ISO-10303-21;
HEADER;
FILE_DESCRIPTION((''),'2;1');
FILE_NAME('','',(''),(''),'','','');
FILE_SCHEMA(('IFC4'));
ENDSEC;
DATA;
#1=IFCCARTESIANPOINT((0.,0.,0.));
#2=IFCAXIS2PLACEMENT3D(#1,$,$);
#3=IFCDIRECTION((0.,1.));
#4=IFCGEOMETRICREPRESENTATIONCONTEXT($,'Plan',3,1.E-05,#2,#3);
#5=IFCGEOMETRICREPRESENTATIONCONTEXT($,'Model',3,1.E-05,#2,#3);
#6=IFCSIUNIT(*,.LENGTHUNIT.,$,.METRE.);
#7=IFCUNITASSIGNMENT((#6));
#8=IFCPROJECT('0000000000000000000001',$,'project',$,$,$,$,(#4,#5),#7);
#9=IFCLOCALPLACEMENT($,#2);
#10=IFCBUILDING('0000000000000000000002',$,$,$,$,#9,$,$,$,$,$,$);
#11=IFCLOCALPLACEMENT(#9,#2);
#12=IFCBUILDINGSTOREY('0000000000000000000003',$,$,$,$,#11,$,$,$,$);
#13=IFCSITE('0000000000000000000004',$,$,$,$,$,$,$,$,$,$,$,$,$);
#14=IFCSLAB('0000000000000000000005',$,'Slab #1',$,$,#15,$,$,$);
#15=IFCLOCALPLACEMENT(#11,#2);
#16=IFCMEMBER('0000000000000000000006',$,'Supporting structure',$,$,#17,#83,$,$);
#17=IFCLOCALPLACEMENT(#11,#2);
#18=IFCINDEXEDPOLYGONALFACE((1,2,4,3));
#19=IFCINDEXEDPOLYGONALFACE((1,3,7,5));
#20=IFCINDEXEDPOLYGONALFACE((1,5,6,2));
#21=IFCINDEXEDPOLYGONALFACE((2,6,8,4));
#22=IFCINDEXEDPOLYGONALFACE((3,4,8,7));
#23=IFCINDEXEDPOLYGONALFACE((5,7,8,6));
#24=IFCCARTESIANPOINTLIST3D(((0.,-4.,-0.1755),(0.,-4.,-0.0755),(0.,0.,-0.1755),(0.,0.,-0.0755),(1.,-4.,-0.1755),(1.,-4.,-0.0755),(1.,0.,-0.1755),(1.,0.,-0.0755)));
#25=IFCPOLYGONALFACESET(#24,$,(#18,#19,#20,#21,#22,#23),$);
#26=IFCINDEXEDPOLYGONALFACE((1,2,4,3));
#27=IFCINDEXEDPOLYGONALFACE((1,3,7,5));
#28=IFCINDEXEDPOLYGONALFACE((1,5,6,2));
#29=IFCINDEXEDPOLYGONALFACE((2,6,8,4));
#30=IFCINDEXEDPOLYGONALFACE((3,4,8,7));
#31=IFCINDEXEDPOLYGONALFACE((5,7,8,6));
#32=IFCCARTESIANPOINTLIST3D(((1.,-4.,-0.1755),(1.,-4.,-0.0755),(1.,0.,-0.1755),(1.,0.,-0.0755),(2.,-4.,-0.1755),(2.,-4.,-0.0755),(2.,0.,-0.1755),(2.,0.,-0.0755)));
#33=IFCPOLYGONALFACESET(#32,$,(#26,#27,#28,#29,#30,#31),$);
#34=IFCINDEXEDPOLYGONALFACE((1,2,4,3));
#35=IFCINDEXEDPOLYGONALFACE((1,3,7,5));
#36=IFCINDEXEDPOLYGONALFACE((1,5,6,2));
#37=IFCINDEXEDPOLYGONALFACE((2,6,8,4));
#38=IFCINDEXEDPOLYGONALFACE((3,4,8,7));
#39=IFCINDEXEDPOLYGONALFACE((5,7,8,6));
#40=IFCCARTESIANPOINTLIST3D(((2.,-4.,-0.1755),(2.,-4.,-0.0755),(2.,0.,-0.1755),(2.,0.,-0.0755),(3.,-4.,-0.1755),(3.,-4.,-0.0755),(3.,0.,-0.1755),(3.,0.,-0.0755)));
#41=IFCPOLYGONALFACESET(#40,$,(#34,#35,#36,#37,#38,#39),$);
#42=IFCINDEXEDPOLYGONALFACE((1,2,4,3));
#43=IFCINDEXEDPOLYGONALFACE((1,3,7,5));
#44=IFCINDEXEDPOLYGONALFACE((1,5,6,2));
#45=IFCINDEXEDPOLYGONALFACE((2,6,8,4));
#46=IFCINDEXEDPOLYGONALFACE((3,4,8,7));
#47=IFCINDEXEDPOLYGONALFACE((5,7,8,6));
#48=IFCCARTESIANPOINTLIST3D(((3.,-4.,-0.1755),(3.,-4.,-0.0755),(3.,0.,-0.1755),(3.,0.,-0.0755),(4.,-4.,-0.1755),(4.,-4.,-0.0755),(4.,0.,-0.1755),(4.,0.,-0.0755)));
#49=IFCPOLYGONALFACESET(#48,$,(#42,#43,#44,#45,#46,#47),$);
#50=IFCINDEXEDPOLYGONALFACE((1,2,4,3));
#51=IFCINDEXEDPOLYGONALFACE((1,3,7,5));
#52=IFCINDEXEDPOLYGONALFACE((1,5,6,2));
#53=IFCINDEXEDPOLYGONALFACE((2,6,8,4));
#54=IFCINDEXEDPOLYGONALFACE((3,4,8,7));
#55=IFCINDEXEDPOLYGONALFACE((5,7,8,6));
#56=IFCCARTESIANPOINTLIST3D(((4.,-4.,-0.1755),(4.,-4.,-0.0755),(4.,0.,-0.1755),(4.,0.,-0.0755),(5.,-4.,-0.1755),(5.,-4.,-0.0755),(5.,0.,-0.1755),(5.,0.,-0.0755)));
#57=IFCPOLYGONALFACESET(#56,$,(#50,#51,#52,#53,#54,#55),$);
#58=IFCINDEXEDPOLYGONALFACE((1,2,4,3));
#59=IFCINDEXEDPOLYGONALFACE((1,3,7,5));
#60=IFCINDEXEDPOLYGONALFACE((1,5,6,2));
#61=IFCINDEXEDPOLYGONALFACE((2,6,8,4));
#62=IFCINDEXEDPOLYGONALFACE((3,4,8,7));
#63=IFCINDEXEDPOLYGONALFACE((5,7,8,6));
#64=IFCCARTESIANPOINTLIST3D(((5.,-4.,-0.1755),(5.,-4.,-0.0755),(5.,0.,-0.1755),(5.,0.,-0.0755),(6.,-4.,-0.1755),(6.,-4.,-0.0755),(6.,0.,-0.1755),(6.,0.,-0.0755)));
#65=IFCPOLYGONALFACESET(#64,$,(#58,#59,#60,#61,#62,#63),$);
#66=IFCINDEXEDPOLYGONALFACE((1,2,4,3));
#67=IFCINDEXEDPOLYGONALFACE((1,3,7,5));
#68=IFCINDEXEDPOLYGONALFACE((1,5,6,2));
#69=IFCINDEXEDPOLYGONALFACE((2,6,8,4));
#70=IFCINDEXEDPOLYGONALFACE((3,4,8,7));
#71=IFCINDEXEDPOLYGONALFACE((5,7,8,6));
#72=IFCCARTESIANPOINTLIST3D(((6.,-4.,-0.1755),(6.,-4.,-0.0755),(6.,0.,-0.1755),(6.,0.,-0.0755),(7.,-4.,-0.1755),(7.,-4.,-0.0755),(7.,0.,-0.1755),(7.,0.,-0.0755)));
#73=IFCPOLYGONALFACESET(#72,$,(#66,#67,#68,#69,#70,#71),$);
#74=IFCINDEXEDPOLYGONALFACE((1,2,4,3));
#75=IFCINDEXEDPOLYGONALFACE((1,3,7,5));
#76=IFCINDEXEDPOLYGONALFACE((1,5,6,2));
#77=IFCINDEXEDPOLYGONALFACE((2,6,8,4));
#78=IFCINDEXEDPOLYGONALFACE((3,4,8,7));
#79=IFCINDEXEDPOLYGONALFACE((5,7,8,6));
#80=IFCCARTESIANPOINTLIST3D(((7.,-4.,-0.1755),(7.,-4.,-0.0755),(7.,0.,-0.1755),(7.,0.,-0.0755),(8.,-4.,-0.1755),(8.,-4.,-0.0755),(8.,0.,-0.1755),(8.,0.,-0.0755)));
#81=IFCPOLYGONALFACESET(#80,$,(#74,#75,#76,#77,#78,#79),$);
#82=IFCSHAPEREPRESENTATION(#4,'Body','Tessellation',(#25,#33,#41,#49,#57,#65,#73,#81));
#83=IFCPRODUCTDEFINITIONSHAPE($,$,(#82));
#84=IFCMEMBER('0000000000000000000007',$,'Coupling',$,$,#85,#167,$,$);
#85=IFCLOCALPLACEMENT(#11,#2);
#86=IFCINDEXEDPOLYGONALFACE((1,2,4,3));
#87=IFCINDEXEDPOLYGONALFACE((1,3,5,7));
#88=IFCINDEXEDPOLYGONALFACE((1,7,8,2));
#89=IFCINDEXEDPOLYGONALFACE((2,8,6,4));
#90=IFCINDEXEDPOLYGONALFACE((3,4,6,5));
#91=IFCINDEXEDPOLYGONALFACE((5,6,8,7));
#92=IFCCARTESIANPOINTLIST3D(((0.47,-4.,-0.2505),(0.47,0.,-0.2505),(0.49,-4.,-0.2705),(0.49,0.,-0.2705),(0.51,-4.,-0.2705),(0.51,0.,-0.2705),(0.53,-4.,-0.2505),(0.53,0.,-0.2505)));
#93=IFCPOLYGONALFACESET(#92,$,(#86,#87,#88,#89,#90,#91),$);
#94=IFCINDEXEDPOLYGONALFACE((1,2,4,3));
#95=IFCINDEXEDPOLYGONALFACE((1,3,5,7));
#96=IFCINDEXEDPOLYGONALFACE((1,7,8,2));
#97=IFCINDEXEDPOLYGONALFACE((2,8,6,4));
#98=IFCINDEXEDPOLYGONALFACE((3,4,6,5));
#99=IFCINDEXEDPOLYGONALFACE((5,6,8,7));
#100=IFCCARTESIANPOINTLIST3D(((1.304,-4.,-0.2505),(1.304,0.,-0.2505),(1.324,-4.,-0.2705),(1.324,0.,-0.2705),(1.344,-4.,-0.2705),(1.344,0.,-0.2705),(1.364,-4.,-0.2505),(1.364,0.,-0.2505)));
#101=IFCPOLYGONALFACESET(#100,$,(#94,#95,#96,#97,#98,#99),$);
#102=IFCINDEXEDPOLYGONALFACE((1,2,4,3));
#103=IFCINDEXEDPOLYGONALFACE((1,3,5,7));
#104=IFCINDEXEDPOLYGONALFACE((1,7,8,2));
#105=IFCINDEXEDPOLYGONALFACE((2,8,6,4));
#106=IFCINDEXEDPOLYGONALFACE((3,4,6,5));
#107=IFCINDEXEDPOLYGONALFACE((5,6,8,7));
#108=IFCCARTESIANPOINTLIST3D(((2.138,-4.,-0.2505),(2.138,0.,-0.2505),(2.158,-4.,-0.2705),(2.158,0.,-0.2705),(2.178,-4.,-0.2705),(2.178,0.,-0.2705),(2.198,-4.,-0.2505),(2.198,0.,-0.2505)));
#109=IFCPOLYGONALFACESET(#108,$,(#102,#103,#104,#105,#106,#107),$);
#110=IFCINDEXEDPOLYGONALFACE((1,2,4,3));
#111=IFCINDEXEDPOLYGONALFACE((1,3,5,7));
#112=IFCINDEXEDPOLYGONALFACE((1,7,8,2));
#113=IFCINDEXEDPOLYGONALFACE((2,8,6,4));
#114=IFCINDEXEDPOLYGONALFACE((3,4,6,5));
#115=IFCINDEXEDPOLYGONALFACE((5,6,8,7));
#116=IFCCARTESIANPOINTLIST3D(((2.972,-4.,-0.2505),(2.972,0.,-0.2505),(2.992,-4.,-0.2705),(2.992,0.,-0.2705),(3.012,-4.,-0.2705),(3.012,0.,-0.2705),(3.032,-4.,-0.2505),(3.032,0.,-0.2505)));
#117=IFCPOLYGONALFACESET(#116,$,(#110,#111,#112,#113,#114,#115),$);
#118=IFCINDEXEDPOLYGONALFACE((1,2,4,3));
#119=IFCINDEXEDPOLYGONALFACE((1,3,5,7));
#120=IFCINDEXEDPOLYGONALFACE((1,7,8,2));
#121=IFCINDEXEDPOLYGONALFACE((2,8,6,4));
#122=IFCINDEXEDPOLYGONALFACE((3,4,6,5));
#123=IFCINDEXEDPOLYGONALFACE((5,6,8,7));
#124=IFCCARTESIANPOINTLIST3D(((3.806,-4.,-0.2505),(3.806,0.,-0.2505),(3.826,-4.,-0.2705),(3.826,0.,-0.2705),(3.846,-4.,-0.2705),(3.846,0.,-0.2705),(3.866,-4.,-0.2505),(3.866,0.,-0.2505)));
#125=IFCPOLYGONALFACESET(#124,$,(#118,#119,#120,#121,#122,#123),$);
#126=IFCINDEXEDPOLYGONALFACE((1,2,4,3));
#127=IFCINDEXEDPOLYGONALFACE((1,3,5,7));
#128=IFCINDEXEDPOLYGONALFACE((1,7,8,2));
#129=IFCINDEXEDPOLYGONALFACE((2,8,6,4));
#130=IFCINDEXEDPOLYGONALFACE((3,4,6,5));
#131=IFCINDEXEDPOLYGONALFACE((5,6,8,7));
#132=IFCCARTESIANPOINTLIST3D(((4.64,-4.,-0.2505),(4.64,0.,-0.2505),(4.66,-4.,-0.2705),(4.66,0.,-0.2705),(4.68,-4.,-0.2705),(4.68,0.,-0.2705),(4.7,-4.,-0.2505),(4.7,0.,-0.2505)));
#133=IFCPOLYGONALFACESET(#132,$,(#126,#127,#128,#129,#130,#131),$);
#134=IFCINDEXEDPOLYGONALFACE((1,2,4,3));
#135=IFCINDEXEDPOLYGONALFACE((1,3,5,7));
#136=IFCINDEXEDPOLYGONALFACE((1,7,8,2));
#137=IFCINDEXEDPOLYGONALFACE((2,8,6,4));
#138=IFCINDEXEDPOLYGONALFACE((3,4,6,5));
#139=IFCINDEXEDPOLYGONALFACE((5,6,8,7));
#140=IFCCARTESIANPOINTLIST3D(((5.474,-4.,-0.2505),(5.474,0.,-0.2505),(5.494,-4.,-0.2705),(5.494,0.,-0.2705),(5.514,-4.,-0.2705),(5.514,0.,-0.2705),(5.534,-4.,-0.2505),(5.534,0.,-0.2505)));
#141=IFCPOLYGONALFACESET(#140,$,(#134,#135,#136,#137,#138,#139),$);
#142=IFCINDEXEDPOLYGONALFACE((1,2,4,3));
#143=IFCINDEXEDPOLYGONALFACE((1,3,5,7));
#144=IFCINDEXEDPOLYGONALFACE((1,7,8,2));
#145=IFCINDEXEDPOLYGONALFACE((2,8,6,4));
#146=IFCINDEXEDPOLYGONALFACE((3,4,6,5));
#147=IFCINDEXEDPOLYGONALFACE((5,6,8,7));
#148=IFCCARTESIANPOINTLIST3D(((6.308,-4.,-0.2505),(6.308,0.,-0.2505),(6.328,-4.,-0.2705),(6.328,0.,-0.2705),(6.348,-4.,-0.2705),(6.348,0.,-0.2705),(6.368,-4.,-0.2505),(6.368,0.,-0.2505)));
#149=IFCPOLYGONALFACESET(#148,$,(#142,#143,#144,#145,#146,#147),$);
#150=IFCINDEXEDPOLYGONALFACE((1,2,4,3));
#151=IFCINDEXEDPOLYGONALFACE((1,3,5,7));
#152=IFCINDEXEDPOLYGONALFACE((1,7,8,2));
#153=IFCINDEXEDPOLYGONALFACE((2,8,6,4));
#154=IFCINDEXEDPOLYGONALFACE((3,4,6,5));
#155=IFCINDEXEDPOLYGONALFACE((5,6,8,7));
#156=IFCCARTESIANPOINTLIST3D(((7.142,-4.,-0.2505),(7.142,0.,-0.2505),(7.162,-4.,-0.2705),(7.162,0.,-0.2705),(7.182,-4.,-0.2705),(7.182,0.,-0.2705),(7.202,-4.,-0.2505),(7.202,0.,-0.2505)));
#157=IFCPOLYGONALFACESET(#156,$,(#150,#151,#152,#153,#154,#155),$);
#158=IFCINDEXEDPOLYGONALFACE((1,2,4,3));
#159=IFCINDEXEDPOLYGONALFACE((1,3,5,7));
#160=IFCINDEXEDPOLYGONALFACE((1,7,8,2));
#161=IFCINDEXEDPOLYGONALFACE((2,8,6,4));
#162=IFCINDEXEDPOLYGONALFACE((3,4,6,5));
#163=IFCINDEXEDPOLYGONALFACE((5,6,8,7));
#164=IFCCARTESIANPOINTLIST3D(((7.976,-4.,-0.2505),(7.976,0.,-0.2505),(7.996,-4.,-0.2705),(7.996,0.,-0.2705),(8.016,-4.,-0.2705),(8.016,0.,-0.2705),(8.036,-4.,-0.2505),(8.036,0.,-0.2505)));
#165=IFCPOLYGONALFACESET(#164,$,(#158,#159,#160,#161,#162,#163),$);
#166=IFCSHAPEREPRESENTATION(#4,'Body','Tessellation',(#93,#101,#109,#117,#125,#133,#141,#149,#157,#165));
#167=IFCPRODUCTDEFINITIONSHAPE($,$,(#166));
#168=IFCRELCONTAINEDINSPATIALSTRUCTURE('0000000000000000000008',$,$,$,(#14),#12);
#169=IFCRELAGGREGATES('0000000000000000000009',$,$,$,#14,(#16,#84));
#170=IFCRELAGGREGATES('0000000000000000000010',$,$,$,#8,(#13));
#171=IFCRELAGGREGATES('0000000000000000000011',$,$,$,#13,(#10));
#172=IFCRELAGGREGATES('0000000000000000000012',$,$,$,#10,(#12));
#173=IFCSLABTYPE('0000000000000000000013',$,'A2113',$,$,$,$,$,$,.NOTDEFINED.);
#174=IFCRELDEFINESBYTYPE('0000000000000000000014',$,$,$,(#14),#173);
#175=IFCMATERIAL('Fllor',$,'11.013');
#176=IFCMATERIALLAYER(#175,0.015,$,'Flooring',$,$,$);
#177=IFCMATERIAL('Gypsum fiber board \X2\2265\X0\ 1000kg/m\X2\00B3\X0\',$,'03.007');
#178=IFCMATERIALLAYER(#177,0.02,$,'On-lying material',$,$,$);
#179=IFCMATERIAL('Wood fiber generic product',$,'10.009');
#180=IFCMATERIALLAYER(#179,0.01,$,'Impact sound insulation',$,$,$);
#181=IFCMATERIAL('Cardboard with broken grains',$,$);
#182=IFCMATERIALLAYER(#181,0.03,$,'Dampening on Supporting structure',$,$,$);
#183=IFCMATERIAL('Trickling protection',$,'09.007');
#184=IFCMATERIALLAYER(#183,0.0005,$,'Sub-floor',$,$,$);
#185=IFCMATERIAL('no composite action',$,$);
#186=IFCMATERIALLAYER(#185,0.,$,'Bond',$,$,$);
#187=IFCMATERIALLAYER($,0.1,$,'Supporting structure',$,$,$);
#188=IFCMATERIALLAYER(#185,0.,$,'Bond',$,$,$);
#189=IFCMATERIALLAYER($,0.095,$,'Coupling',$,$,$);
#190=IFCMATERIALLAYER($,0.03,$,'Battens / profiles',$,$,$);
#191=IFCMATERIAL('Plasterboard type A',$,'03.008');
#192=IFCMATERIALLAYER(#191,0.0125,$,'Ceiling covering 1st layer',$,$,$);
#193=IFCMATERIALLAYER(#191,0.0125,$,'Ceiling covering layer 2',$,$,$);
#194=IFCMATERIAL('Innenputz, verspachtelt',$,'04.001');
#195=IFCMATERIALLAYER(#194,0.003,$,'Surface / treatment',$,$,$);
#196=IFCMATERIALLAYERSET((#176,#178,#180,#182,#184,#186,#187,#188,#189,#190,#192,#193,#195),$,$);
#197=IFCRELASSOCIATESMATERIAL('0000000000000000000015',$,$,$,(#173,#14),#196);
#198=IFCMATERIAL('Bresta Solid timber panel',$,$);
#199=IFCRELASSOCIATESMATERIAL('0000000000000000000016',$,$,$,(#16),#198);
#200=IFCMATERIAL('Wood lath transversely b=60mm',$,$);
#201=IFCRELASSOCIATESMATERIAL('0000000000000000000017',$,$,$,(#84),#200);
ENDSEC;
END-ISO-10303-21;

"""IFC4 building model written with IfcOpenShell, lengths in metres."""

from ifc_helpers import new_model, si_unit, direction, frame, frame_2d, origin, place, context, project, spatial, polyline, rectangle, outline, extrude, material, layer, layer_set, type_object, element, aggregate, save


model = new_model("IFC4")

# Units and contexts
plan_context = context("Plan", 3, precision=1e-05, world=origin(), true_north=direction((0.0, 1.0)))
model_context = context("Model", 3, precision=1e-05, world=origin(), true_north=direction((0.0, 1.0)))
ifc_project = project(units=[si_unit("LENGTHUNIT", "METRE")], contexts=[plan_context, model_context])

# Site, building, storey
site = spatial("IfcSite", under=ifc_project)
building_placement = place(None, origin())
building = spatial("IfcBuilding", under=site, at=building_placement)
storey_placement = place(building_placement, origin())
storey = spatial("IfcBuildingStorey", under=building, at=storey_placement)

# Slab, members
ifc_material_1 = material(Name="Fllor", Category="11.013")
ifc_layer_1 = layer(ifc_material_1, 0.015, Name="Flooring")
ifc_material_2 = material(Name="Gypsum fiber board ≥ 1000kg/m³", Category="03.007")
ifc_layer_2 = layer(ifc_material_2, 0.02, Name="On-lying material")
ifc_material_3 = material(Name="Wood fiber generic product", Category="10.009")
ifc_layer_3 = layer(ifc_material_3, 0.01, Name="Impact sound insulation")
ifc_material_4 = material(Name="Cardboard with broken grains")
ifc_layer_4 = layer(ifc_material_4, 0.03, Name="Dampening on Supporting structure")
ifc_material_5 = material(Name="Trickling protection", Category="09.007")
ifc_layer_5 = layer(ifc_material_5, 0.0005, Name="Sub-floor")
ifc_material_6 = material(Name="no composite action")
ifc_layer_6 = layer(ifc_material_6, 0.0, Name="Bond")
ifc_layer_7 = layer(None, 0.1, Name="Supporting structure")
ifc_layer_8 = layer(ifc_material_6, 0.0, Name="Bond")
ifc_layer_9 = layer(None, 0.095, Name="Coupling")
ifc_layer_10 = layer(None, 0.03, Name="Battens / profiles")
ifc_material_7 = material(Name="Plasterboard type A", Category="03.008")
ifc_layer_11 = layer(ifc_material_7, 0.0125, Name="Ceiling covering 1st layer")
ifc_layer_12 = layer(ifc_material_7, 0.0125, Name="Ceiling covering layer 2")
ifc_material_8 = material(Name="Innenputz, verspachtelt", Category="04.001")
ifc_layer_13 = layer(ifc_material_8, 0.003, Name="Surface / treatment")
ifc_layer_set = layer_set([ifc_layer_1, ifc_layer_2, ifc_layer_3, ifc_layer_4, ifc_layer_5, ifc_layer_6, ifc_layer_7, ifc_layer_8, ifc_layer_9, ifc_layer_10, ifc_layer_11, ifc_layer_12, ifc_layer_13])
slab_type = type_object("IfcSlabType", Name="A2113", PredefinedType="NOTDEFINED", material=ifc_layer_set)
slab_placement = place(None, frame((0.0, 0.0, 0.0), z_axis=(0.0, 0.0, -1.0), x_axis=(1.0, 0.0, 0.0)))
slab = element("IfcSlab", 1, at=slab_placement, inside=storey, type_object=slab_type, material=ifc_layer_set, Name="Slab #1")
ifc_material_9 = material(Name="Bresta Solid timber panel")
member_1_placement = place(slab_placement, origin())
member_1 = element("IfcMember", 2, at=member_1_placement, material=ifc_material_9, Name="Supporting structure", context=plan_context, shape_type="SweptSolid", body=[
    extrude(rectangle(XDim=1.0, YDim=0.1, at=frame_2d((0.5, 0.05), x_axis=(1.0, 0.0))), frame((0.0, 4.0, 0.0755), z_axis=(0.0, -1.0, 0.0), x_axis=(1.0, 0.0, 0.0)), (0.0, 0.0, 1.0), 4.0),
    extrude(rectangle(XDim=1.0, YDim=0.1, at=frame_2d((0.5, 0.05), x_axis=(1.0, 0.0))), frame((1.0, 4.0, 0.0755), z_axis=(0.0, -1.0, 0.0), x_axis=(1.0, 0.0, 0.0)), (0.0, 0.0, 1.0), 4.0),
    extrude(rectangle(XDim=1.0, YDim=0.1, at=frame_2d((0.5, 0.05), x_axis=(1.0, 0.0))), frame((2.0, 4.0, 0.0755), z_axis=(0.0, -1.0, 0.0), x_axis=(1.0, 0.0, 0.0)), (0.0, 0.0, 1.0), 4.0),
    extrude(rectangle(XDim=1.0, YDim=0.1, at=frame_2d((0.5, 0.05), x_axis=(1.0, 0.0))), frame((3.0, 4.0, 0.0755), z_axis=(0.0, -1.0, 0.0), x_axis=(1.0, 0.0, 0.0)), (0.0, 0.0, 1.0), 4.0),
    extrude(rectangle(XDim=1.0, YDim=0.1, at=frame_2d((0.5, 0.05), x_axis=(1.0, 0.0))), frame((4.0, 4.0, 0.0755), z_axis=(0.0, -1.0, 0.0), x_axis=(1.0, 0.0, 0.0)), (0.0, 0.0, 1.0), 4.0),
    extrude(rectangle(XDim=1.0, YDim=0.1, at=frame_2d((0.5, 0.05), x_axis=(1.0, 0.0))), frame((5.0, 4.0, 0.0755), z_axis=(0.0, -1.0, 0.0), x_axis=(1.0, 0.0, 0.0)), (0.0, 0.0, 1.0), 4.0),
    extrude(rectangle(XDim=1.0, YDim=0.1, at=frame_2d((0.5, 0.05), x_axis=(1.0, 0.0))), frame((6.0, 4.0, 0.0755), z_axis=(0.0, -1.0, 0.0), x_axis=(1.0, 0.0, 0.0)), (0.0, 0.0, 1.0), 4.0),
    extrude(rectangle(XDim=1.0, YDim=0.1, at=frame_2d((0.5, 0.05), x_axis=(1.0, 0.0))), frame((7.0, 4.0, 0.0755), z_axis=(0.0, -1.0, 0.0), x_axis=(1.0, 0.0, 0.0)), (0.0, 0.0, 1.0), 4.0),
])
ifc_material_10 = material(Name="Wood lath transversely b=60mm")
member_2_placement = place(slab_placement, origin())
member_2 = element("IfcMember", 3, at=member_2_placement, material=ifc_material_10, Name="Coupling", context=plan_context, shape_type="SweptSolid", body=[
    extrude(outline(polyline([(0.0, 0.0), (0.06, 0.0), (0.04, 0.02), (0.02, 0.02), (0.0, 0.0)])), frame((0.47, 4.0, 0.2505), z_axis=(0.0, -1.0, 0.0), x_axis=(1.0, 0.0, 0.0)), (0.0, 0.0, 1.0), 4.0),
    extrude(outline(polyline([(0.0, 0.0), (0.06, 0.0), (0.04, 0.02), (0.02, 0.02), (0.0, 0.0)])), frame((1.304, 4.0, 0.2505), z_axis=(0.0, -1.0, 0.0), x_axis=(1.0, 0.0, 0.0)), (0.0, 0.0, 1.0), 4.0),
    extrude(outline(polyline([(0.0, 0.0), (0.06, 0.0), (0.04, 0.02), (0.02, 0.02), (0.0, 0.0)])), frame((2.138, 4.0, 0.2505), z_axis=(0.0, -1.0, 0.0), x_axis=(1.0, 0.0, 0.0)), (0.0, 0.0, 1.0), 4.0),
    extrude(outline(polyline([(0.0, 0.0), (0.06, 0.0), (0.04, 0.02), (0.02, 0.02), (0.0, 0.0)])), frame((2.972, 4.0, 0.2505), z_axis=(0.0, -1.0, 0.0), x_axis=(1.0, 0.0, 0.0)), (0.0, 0.0, 1.0), 4.0),
    extrude(outline(polyline([(0.0, 0.0), (0.06, 0.0), (0.04, 0.02), (0.02, 0.02), (0.0, 0.0)])), frame((3.806, 4.0, 0.2505), z_axis=(0.0, -1.0, 0.0), x_axis=(1.0, 0.0, 0.0)), (0.0, 0.0, 1.0), 4.0),
    extrude(outline(polyline([(0.0, 0.0), (0.06, 0.0), (0.04, 0.02), (0.02, 0.02), (0.0, 0.0)])), frame((4.64, 4.0, 0.2505), z_axis=(0.0, -1.0, 0.0), x_axis=(1.0, 0.0, 0.0)), (0.0, 0.0, 1.0), 4.0),
    extrude(outline(polyline([(0.0, 0.0), (0.06, 0.0), (0.04, 0.02), (0.02, 0.02), (0.0, 0.0)])), frame((5.474, 4.0, 0.2505), z_axis=(0.0, -1.0, 0.0), x_axis=(1.0, 0.0, 0.0)), (0.0, 0.0, 1.0), 4.0),
    extrude(outline(polyline([(0.0, 0.0), (0.06, 0.0), (0.04, 0.02), (0.02, 0.02), (0.0, 0.0)])), frame((6.308, 4.0, 0.2505), z_axis=(0.0, -1.0, 0.0), x_axis=(1.0, 0.0, 0.0)), (0.0, 0.0, 1.0), 4.0),
    extrude(outline(polyline([(0.0, 0.0), (0.06, 0.0), (0.04, 0.02), (0.02, 0.02), (0.0, 0.0)])), frame((7.142, 4.0, 0.2505), z_axis=(0.0, -1.0, 0.0), x_axis=(1.0, 0.0, 0.0)), (0.0, 0.0, 1.0), 4.0),
    extrude(outline(polyline([(0.0, 0.0), (0.06, 0.0), (0.04, 0.02), (0.02, 0.02), (0.0, 0.0)])), frame((7.976, 4.0, 0.2505), z_axis=(0.0, -1.0, 0.0), x_axis=(1.0, 0.0, 0.0)), (0.0, 0.0, 1.0), 4.0),
])
aggregate(slab, [member_1, member_2])

save(model, "model.ifc")
